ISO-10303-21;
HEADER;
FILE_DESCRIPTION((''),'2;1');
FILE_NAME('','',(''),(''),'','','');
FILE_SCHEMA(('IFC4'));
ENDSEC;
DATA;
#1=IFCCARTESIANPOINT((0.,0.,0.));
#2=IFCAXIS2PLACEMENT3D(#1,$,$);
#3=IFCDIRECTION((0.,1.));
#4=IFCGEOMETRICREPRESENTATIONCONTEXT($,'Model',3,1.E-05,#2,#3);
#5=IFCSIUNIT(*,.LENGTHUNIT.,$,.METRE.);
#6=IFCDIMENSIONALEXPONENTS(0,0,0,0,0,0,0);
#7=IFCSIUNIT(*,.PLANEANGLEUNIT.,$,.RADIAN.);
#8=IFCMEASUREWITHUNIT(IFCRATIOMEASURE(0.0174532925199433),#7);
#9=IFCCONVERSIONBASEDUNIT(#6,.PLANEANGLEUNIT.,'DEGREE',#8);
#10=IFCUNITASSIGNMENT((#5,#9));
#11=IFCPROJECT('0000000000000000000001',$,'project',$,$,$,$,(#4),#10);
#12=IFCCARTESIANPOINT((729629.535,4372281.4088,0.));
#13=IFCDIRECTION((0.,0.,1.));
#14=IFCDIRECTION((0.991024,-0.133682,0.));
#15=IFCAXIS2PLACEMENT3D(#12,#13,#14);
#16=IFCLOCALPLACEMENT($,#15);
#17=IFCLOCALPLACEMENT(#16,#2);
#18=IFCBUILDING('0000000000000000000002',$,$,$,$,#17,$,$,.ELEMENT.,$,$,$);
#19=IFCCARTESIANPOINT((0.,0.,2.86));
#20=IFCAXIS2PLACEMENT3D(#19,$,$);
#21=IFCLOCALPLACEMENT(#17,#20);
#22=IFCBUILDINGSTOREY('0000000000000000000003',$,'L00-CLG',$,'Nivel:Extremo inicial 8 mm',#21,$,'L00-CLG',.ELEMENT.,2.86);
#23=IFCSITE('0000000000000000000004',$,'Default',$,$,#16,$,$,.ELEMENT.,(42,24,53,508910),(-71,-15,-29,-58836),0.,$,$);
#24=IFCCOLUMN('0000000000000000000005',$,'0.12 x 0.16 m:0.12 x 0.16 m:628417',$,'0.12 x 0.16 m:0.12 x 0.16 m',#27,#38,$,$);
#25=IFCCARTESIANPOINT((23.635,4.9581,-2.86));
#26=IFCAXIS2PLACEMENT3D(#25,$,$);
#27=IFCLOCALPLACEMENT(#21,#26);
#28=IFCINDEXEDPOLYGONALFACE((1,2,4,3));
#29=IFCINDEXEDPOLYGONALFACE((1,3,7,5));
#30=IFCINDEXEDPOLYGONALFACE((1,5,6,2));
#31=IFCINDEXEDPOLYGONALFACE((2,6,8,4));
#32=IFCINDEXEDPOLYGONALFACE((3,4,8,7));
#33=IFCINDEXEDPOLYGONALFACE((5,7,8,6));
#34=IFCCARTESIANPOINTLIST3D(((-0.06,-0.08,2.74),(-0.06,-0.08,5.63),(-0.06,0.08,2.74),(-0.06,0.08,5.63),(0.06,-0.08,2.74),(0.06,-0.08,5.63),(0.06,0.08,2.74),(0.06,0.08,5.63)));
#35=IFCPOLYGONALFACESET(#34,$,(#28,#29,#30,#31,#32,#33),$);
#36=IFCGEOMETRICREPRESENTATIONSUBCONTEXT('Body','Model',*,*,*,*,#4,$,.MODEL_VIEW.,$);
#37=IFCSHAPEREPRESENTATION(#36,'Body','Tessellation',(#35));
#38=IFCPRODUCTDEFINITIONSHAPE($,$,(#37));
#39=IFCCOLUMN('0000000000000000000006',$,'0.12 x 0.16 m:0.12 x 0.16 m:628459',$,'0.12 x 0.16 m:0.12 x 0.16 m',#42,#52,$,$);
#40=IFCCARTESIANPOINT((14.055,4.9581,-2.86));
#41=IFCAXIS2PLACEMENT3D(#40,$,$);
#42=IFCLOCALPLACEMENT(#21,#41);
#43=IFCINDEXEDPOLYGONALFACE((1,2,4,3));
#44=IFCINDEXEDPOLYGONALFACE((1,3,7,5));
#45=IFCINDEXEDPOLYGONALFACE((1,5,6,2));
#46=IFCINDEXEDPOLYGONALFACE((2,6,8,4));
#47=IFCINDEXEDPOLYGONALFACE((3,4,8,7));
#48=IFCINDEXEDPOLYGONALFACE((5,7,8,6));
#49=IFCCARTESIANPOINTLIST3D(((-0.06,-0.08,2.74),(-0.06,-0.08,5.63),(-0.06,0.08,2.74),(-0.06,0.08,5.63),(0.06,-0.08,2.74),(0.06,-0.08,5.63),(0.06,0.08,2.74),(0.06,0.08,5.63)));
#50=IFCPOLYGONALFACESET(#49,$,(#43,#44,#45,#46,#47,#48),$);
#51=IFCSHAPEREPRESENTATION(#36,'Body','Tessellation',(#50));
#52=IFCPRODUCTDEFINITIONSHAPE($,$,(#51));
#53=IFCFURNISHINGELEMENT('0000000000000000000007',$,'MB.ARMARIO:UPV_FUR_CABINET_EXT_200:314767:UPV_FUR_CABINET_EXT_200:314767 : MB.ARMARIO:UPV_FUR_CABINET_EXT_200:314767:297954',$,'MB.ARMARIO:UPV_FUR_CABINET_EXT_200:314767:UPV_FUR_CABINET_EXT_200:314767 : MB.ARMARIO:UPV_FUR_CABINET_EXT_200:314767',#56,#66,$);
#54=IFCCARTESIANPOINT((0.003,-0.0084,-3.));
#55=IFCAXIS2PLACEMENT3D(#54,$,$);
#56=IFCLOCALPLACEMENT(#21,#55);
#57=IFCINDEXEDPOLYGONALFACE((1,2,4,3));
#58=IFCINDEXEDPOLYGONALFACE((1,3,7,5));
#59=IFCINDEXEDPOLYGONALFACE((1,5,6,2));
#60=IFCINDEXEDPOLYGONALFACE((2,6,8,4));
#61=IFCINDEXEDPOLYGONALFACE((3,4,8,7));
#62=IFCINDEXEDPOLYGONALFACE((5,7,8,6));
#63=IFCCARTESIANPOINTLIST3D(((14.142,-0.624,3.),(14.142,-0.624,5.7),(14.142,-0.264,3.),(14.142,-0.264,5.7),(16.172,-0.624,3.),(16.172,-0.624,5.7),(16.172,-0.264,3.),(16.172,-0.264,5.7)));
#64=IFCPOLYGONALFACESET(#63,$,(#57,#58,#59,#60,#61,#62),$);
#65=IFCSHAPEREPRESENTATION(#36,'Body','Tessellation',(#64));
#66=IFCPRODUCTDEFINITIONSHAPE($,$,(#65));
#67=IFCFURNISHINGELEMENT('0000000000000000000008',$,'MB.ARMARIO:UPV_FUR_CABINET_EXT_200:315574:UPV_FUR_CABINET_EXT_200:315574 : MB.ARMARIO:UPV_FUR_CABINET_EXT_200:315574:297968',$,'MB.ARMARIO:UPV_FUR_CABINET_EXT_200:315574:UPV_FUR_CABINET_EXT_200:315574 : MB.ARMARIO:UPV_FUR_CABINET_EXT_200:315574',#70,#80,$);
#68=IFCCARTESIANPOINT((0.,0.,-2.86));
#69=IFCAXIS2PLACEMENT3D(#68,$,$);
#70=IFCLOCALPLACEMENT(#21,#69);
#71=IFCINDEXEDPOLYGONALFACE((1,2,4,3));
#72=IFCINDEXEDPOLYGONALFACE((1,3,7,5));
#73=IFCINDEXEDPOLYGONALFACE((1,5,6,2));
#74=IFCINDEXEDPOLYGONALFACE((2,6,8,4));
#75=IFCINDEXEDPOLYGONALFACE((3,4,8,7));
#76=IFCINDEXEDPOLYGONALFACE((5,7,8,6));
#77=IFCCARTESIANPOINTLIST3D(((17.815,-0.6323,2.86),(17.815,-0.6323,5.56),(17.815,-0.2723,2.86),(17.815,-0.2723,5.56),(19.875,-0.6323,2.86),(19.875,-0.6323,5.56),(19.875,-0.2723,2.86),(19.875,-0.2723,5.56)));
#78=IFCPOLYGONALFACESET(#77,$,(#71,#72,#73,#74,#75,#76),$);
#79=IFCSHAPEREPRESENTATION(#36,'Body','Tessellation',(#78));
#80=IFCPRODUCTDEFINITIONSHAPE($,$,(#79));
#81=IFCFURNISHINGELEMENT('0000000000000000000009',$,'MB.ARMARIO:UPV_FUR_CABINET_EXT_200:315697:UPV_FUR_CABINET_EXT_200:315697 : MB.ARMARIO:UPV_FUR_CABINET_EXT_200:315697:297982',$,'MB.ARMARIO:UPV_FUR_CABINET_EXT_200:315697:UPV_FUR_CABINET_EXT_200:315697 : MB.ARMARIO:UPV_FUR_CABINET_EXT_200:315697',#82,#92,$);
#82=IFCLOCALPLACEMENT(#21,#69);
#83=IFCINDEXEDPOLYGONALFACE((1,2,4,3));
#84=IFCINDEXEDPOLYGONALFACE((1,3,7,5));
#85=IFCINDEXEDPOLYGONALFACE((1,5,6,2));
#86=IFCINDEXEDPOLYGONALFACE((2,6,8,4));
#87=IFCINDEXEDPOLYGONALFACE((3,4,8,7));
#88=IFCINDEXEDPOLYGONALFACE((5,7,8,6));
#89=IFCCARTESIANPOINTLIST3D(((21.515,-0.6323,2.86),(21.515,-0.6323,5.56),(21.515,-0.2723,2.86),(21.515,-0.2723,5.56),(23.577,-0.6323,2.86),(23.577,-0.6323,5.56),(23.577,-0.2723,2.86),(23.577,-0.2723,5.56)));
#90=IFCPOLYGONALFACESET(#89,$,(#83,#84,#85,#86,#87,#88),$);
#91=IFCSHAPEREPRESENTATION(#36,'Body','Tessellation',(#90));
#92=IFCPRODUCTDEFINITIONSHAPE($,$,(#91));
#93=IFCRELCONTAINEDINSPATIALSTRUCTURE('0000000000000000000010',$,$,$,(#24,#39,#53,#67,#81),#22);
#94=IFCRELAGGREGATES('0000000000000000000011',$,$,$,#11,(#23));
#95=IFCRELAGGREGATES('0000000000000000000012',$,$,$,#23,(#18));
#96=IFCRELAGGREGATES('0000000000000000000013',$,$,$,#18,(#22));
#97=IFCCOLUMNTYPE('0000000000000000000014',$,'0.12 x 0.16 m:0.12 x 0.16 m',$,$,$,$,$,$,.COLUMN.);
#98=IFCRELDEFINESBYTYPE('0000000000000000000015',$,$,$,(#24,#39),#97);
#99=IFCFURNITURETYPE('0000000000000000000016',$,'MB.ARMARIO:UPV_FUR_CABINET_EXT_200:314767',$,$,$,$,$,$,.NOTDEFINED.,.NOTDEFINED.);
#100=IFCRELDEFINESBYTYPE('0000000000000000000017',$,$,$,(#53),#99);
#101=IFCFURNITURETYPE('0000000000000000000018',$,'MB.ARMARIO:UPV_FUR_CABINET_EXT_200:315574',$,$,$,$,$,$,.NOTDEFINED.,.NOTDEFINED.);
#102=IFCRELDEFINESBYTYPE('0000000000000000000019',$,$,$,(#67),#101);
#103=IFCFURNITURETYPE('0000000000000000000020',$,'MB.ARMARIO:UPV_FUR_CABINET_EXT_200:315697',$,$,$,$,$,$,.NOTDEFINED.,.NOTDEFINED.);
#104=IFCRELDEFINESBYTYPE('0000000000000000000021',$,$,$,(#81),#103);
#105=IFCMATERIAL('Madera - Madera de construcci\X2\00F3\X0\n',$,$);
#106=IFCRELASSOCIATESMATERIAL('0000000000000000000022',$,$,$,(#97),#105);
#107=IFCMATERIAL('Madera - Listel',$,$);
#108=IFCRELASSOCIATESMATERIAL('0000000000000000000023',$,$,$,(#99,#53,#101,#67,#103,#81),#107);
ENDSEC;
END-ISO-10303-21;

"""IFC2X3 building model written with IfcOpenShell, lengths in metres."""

from ifc_helpers import new_model, entity, si_unit, converted_unit, direction, frame, frame_2d, origin, place, context, subcontext, project, spatial, rectangle, extrude, source, transform, mapped, material, type_object, type_shapes, element, save


model = new_model("IFC2X3")

# Units and contexts
model_context = context("Model", 3, precision=1e-05, world=origin(), true_north=direction((0.0, 1.0)))
body_context = subcontext(model_context, "Body", "Model", "MODEL_VIEW")
ifc_project = project(units=[si_unit("LENGTHUNIT", "METRE"), converted_unit("PLANEANGLEUNIT", "DEGREE", entity("IfcRatioMeasure", 0.0174532925199433), si_unit("PLANEANGLEUNIT", "RADIAN"), dimensions=[0, 0, 0, 0, 0, 0, 0])], contexts=[model_context])

# Site, building, storey
site_placement = place(None, frame((729629.535, 4372281.4088, 0.0), z_axis=(0.0, 0.0, 1.0), x_axis=(0.991024, -0.133682, 0.0)))
site = spatial("IfcSite", under=ifc_project, at=site_placement, Name="Default", CompositionType="ELEMENT", RefLatitude=(42, 24, 53, 508910), RefLongitude=(-71, -15, -29, -58836), RefElevation=0.0)
building_placement = place(site_placement, origin())
building = spatial("IfcBuilding", under=site, at=building_placement, CompositionType="ELEMENT")
storey_placement = place(building_placement, frame((0.0, 0.0, 2.86)))
storey = spatial("IfcBuildingStorey", under=building, at=storey_placement, Name="L00-CLG", ObjectType="Nivel:Extremo inicial 8 mm", LongName="L00-CLG", CompositionType="ELEMENT", Elevation=2.86)

# Columns
ifc_material_1 = material(Name="Madera - Madera de construcción")
column_type = type_object("IfcColumnType", Name="0.12 x 0.16 m:0.12 x 0.16 m", PredefinedType="COLUMN", material=ifc_material_1)
shared_shape_1 = source(origin(), body_context, "Body", "SweptSolid", [
    extrude(rectangle(XDim=0.16, YDim=0.12, at=frame_2d((0.0, 0.0), x_axis=(1.0, 0.0))), frame((0.0, 0.0, 2.74), z_axis=(0.0, 0.0, 1.0), x_axis=(0.0, -1.0, 0.0)), (0.0, 0.0, 1.0), 2.89),
])
type_shapes(column_type, [shared_shape_1])
for number, where, name in (
    (1, (23.635, 4.9581, -2.86), "0.12 x 0.16 m:0.12 x 0.16 m:628417"),
    (2, (14.055, 4.9581, -2.86), "0.12 x 0.16 m:0.12 x 0.16 m:628459"),
):
    element("IfcColumn", number, at=place(storey_placement, frame(where)), inside=storey, type_object=column_type, Name=name, ObjectType="0.12 x 0.16 m:0.12 x 0.16 m", context=body_context, shape_type="MappedRepresentation", body=[
        mapped(shared_shape_1, transform((0.0, 0.0, 0.0), scale=1.0)),
    ])

# Furnishing elements
ifc_material_2 = material(Name="Madera - Listel")
furniture_type_1 = type_object("IfcFurnitureType", Name="MB.ARMARIO:UPV_FUR_CABINET_EXT_200:314767", material=ifc_material_2)
shared_shape_2 = source(origin(), body_context, "Body", "SweptSolid", [
    extrude(rectangle(XDim=0.36, YDim=2.03, at=frame_2d((0.0, 0.0), x_axis=(1.0, 0.0))), frame((15.157, -0.444, 3.0), z_axis=(0.0, 0.0, 1.0), x_axis=(0.0, -1.0, 0.0)), (0.0, 0.0, 1.0), 2.7),
])
type_shapes(furniture_type_1, [shared_shape_2])
furnishing_1_placement = place(storey_placement, frame((0.003, -0.0084, -3.0)))
element("IfcFurnishingElement", 3, at=furnishing_1_placement, inside=storey, type_object=furniture_type_1, material=ifc_material_2, Name="MB.ARMARIO:UPV_FUR_CABINET_EXT_200:314767:UPV_FUR_CABINET_EXT_200:314767 : MB.ARMARIO:UPV_FUR_CABINET_EXT_200:314767:297954", ObjectType="MB.ARMARIO:UPV_FUR_CABINET_EXT_200:314767:UPV_FUR_CABINET_EXT_200:314767 : MB.ARMARIO:UPV_FUR_CABINET_EXT_200:314767", context=body_context, shape_type="MappedRepresentation", body=[
    mapped(shared_shape_2, transform((0.0, 0.0, 0.0), scale=1.0)),
])
furniture_type_2 = type_object("IfcFurnitureType", Name="MB.ARMARIO:UPV_FUR_CABINET_EXT_200:315574", material=ifc_material_2)
shared_shape_3 = source(origin(), body_context, "Body", "SweptSolid", [
    extrude(rectangle(XDim=0.36, YDim=2.06, at=frame_2d((0.0, 0.0), x_axis=(1.0, 0.0))), frame((18.845, -0.4523, 2.86), z_axis=(0.0, 0.0, 1.0), x_axis=(0.0, -1.0, 0.0)), (0.0, 0.0, 1.0), 2.7),
])
type_shapes(furniture_type_2, [shared_shape_3])
furnishing_2_placement = place(storey_placement, frame((0.0, 0.0, -2.86)))
element("IfcFurnishingElement", 4, at=furnishing_2_placement, inside=storey, type_object=furniture_type_2, material=ifc_material_2, Name="MB.ARMARIO:UPV_FUR_CABINET_EXT_200:315574:UPV_FUR_CABINET_EXT_200:315574 : MB.ARMARIO:UPV_FUR_CABINET_EXT_200:315574:297968", ObjectType="MB.ARMARIO:UPV_FUR_CABINET_EXT_200:315574:UPV_FUR_CABINET_EXT_200:315574 : MB.ARMARIO:UPV_FUR_CABINET_EXT_200:315574", context=body_context, shape_type="MappedRepresentation", body=[
    mapped(shared_shape_3, transform((0.0, 0.0, 0.0), scale=1.0)),
])
furniture_type_3 = type_object("IfcFurnitureType", Name="MB.ARMARIO:UPV_FUR_CABINET_EXT_200:315697", material=ifc_material_2)
shared_shape_4 = source(origin(), body_context, "Body", "SweptSolid", [
    extrude(rectangle(XDim=0.36, YDim=2.062, at=frame_2d((0.0, 0.0), x_axis=(1.0, 0.0))), frame((22.546, -0.4523, 2.86), z_axis=(0.0, 0.0, 1.0), x_axis=(0.0, -1.0, 0.0)), (0.0, 0.0, 1.0), 2.7),
])
type_shapes(furniture_type_3, [shared_shape_4])
furnishing_3_placement = place(storey_placement, frame((0.0, 0.0, -2.86)))
element("IfcFurnishingElement", 5, at=furnishing_3_placement, inside=storey, type_object=furniture_type_3, material=ifc_material_2, Name="MB.ARMARIO:UPV_FUR_CABINET_EXT_200:315697:UPV_FUR_CABINET_EXT_200:315697 : MB.ARMARIO:UPV_FUR_CABINET_EXT_200:315697:297982", ObjectType="MB.ARMARIO:UPV_FUR_CABINET_EXT_200:315697:UPV_FUR_CABINET_EXT_200:315697 : MB.ARMARIO:UPV_FUR_CABINET_EXT_200:315697", context=body_context, shape_type="MappedRepresentation", body=[
    mapped(shared_shape_4, transform((0.0, 0.0, 0.0), scale=1.0)),
])

save(model, "model.ifc")
